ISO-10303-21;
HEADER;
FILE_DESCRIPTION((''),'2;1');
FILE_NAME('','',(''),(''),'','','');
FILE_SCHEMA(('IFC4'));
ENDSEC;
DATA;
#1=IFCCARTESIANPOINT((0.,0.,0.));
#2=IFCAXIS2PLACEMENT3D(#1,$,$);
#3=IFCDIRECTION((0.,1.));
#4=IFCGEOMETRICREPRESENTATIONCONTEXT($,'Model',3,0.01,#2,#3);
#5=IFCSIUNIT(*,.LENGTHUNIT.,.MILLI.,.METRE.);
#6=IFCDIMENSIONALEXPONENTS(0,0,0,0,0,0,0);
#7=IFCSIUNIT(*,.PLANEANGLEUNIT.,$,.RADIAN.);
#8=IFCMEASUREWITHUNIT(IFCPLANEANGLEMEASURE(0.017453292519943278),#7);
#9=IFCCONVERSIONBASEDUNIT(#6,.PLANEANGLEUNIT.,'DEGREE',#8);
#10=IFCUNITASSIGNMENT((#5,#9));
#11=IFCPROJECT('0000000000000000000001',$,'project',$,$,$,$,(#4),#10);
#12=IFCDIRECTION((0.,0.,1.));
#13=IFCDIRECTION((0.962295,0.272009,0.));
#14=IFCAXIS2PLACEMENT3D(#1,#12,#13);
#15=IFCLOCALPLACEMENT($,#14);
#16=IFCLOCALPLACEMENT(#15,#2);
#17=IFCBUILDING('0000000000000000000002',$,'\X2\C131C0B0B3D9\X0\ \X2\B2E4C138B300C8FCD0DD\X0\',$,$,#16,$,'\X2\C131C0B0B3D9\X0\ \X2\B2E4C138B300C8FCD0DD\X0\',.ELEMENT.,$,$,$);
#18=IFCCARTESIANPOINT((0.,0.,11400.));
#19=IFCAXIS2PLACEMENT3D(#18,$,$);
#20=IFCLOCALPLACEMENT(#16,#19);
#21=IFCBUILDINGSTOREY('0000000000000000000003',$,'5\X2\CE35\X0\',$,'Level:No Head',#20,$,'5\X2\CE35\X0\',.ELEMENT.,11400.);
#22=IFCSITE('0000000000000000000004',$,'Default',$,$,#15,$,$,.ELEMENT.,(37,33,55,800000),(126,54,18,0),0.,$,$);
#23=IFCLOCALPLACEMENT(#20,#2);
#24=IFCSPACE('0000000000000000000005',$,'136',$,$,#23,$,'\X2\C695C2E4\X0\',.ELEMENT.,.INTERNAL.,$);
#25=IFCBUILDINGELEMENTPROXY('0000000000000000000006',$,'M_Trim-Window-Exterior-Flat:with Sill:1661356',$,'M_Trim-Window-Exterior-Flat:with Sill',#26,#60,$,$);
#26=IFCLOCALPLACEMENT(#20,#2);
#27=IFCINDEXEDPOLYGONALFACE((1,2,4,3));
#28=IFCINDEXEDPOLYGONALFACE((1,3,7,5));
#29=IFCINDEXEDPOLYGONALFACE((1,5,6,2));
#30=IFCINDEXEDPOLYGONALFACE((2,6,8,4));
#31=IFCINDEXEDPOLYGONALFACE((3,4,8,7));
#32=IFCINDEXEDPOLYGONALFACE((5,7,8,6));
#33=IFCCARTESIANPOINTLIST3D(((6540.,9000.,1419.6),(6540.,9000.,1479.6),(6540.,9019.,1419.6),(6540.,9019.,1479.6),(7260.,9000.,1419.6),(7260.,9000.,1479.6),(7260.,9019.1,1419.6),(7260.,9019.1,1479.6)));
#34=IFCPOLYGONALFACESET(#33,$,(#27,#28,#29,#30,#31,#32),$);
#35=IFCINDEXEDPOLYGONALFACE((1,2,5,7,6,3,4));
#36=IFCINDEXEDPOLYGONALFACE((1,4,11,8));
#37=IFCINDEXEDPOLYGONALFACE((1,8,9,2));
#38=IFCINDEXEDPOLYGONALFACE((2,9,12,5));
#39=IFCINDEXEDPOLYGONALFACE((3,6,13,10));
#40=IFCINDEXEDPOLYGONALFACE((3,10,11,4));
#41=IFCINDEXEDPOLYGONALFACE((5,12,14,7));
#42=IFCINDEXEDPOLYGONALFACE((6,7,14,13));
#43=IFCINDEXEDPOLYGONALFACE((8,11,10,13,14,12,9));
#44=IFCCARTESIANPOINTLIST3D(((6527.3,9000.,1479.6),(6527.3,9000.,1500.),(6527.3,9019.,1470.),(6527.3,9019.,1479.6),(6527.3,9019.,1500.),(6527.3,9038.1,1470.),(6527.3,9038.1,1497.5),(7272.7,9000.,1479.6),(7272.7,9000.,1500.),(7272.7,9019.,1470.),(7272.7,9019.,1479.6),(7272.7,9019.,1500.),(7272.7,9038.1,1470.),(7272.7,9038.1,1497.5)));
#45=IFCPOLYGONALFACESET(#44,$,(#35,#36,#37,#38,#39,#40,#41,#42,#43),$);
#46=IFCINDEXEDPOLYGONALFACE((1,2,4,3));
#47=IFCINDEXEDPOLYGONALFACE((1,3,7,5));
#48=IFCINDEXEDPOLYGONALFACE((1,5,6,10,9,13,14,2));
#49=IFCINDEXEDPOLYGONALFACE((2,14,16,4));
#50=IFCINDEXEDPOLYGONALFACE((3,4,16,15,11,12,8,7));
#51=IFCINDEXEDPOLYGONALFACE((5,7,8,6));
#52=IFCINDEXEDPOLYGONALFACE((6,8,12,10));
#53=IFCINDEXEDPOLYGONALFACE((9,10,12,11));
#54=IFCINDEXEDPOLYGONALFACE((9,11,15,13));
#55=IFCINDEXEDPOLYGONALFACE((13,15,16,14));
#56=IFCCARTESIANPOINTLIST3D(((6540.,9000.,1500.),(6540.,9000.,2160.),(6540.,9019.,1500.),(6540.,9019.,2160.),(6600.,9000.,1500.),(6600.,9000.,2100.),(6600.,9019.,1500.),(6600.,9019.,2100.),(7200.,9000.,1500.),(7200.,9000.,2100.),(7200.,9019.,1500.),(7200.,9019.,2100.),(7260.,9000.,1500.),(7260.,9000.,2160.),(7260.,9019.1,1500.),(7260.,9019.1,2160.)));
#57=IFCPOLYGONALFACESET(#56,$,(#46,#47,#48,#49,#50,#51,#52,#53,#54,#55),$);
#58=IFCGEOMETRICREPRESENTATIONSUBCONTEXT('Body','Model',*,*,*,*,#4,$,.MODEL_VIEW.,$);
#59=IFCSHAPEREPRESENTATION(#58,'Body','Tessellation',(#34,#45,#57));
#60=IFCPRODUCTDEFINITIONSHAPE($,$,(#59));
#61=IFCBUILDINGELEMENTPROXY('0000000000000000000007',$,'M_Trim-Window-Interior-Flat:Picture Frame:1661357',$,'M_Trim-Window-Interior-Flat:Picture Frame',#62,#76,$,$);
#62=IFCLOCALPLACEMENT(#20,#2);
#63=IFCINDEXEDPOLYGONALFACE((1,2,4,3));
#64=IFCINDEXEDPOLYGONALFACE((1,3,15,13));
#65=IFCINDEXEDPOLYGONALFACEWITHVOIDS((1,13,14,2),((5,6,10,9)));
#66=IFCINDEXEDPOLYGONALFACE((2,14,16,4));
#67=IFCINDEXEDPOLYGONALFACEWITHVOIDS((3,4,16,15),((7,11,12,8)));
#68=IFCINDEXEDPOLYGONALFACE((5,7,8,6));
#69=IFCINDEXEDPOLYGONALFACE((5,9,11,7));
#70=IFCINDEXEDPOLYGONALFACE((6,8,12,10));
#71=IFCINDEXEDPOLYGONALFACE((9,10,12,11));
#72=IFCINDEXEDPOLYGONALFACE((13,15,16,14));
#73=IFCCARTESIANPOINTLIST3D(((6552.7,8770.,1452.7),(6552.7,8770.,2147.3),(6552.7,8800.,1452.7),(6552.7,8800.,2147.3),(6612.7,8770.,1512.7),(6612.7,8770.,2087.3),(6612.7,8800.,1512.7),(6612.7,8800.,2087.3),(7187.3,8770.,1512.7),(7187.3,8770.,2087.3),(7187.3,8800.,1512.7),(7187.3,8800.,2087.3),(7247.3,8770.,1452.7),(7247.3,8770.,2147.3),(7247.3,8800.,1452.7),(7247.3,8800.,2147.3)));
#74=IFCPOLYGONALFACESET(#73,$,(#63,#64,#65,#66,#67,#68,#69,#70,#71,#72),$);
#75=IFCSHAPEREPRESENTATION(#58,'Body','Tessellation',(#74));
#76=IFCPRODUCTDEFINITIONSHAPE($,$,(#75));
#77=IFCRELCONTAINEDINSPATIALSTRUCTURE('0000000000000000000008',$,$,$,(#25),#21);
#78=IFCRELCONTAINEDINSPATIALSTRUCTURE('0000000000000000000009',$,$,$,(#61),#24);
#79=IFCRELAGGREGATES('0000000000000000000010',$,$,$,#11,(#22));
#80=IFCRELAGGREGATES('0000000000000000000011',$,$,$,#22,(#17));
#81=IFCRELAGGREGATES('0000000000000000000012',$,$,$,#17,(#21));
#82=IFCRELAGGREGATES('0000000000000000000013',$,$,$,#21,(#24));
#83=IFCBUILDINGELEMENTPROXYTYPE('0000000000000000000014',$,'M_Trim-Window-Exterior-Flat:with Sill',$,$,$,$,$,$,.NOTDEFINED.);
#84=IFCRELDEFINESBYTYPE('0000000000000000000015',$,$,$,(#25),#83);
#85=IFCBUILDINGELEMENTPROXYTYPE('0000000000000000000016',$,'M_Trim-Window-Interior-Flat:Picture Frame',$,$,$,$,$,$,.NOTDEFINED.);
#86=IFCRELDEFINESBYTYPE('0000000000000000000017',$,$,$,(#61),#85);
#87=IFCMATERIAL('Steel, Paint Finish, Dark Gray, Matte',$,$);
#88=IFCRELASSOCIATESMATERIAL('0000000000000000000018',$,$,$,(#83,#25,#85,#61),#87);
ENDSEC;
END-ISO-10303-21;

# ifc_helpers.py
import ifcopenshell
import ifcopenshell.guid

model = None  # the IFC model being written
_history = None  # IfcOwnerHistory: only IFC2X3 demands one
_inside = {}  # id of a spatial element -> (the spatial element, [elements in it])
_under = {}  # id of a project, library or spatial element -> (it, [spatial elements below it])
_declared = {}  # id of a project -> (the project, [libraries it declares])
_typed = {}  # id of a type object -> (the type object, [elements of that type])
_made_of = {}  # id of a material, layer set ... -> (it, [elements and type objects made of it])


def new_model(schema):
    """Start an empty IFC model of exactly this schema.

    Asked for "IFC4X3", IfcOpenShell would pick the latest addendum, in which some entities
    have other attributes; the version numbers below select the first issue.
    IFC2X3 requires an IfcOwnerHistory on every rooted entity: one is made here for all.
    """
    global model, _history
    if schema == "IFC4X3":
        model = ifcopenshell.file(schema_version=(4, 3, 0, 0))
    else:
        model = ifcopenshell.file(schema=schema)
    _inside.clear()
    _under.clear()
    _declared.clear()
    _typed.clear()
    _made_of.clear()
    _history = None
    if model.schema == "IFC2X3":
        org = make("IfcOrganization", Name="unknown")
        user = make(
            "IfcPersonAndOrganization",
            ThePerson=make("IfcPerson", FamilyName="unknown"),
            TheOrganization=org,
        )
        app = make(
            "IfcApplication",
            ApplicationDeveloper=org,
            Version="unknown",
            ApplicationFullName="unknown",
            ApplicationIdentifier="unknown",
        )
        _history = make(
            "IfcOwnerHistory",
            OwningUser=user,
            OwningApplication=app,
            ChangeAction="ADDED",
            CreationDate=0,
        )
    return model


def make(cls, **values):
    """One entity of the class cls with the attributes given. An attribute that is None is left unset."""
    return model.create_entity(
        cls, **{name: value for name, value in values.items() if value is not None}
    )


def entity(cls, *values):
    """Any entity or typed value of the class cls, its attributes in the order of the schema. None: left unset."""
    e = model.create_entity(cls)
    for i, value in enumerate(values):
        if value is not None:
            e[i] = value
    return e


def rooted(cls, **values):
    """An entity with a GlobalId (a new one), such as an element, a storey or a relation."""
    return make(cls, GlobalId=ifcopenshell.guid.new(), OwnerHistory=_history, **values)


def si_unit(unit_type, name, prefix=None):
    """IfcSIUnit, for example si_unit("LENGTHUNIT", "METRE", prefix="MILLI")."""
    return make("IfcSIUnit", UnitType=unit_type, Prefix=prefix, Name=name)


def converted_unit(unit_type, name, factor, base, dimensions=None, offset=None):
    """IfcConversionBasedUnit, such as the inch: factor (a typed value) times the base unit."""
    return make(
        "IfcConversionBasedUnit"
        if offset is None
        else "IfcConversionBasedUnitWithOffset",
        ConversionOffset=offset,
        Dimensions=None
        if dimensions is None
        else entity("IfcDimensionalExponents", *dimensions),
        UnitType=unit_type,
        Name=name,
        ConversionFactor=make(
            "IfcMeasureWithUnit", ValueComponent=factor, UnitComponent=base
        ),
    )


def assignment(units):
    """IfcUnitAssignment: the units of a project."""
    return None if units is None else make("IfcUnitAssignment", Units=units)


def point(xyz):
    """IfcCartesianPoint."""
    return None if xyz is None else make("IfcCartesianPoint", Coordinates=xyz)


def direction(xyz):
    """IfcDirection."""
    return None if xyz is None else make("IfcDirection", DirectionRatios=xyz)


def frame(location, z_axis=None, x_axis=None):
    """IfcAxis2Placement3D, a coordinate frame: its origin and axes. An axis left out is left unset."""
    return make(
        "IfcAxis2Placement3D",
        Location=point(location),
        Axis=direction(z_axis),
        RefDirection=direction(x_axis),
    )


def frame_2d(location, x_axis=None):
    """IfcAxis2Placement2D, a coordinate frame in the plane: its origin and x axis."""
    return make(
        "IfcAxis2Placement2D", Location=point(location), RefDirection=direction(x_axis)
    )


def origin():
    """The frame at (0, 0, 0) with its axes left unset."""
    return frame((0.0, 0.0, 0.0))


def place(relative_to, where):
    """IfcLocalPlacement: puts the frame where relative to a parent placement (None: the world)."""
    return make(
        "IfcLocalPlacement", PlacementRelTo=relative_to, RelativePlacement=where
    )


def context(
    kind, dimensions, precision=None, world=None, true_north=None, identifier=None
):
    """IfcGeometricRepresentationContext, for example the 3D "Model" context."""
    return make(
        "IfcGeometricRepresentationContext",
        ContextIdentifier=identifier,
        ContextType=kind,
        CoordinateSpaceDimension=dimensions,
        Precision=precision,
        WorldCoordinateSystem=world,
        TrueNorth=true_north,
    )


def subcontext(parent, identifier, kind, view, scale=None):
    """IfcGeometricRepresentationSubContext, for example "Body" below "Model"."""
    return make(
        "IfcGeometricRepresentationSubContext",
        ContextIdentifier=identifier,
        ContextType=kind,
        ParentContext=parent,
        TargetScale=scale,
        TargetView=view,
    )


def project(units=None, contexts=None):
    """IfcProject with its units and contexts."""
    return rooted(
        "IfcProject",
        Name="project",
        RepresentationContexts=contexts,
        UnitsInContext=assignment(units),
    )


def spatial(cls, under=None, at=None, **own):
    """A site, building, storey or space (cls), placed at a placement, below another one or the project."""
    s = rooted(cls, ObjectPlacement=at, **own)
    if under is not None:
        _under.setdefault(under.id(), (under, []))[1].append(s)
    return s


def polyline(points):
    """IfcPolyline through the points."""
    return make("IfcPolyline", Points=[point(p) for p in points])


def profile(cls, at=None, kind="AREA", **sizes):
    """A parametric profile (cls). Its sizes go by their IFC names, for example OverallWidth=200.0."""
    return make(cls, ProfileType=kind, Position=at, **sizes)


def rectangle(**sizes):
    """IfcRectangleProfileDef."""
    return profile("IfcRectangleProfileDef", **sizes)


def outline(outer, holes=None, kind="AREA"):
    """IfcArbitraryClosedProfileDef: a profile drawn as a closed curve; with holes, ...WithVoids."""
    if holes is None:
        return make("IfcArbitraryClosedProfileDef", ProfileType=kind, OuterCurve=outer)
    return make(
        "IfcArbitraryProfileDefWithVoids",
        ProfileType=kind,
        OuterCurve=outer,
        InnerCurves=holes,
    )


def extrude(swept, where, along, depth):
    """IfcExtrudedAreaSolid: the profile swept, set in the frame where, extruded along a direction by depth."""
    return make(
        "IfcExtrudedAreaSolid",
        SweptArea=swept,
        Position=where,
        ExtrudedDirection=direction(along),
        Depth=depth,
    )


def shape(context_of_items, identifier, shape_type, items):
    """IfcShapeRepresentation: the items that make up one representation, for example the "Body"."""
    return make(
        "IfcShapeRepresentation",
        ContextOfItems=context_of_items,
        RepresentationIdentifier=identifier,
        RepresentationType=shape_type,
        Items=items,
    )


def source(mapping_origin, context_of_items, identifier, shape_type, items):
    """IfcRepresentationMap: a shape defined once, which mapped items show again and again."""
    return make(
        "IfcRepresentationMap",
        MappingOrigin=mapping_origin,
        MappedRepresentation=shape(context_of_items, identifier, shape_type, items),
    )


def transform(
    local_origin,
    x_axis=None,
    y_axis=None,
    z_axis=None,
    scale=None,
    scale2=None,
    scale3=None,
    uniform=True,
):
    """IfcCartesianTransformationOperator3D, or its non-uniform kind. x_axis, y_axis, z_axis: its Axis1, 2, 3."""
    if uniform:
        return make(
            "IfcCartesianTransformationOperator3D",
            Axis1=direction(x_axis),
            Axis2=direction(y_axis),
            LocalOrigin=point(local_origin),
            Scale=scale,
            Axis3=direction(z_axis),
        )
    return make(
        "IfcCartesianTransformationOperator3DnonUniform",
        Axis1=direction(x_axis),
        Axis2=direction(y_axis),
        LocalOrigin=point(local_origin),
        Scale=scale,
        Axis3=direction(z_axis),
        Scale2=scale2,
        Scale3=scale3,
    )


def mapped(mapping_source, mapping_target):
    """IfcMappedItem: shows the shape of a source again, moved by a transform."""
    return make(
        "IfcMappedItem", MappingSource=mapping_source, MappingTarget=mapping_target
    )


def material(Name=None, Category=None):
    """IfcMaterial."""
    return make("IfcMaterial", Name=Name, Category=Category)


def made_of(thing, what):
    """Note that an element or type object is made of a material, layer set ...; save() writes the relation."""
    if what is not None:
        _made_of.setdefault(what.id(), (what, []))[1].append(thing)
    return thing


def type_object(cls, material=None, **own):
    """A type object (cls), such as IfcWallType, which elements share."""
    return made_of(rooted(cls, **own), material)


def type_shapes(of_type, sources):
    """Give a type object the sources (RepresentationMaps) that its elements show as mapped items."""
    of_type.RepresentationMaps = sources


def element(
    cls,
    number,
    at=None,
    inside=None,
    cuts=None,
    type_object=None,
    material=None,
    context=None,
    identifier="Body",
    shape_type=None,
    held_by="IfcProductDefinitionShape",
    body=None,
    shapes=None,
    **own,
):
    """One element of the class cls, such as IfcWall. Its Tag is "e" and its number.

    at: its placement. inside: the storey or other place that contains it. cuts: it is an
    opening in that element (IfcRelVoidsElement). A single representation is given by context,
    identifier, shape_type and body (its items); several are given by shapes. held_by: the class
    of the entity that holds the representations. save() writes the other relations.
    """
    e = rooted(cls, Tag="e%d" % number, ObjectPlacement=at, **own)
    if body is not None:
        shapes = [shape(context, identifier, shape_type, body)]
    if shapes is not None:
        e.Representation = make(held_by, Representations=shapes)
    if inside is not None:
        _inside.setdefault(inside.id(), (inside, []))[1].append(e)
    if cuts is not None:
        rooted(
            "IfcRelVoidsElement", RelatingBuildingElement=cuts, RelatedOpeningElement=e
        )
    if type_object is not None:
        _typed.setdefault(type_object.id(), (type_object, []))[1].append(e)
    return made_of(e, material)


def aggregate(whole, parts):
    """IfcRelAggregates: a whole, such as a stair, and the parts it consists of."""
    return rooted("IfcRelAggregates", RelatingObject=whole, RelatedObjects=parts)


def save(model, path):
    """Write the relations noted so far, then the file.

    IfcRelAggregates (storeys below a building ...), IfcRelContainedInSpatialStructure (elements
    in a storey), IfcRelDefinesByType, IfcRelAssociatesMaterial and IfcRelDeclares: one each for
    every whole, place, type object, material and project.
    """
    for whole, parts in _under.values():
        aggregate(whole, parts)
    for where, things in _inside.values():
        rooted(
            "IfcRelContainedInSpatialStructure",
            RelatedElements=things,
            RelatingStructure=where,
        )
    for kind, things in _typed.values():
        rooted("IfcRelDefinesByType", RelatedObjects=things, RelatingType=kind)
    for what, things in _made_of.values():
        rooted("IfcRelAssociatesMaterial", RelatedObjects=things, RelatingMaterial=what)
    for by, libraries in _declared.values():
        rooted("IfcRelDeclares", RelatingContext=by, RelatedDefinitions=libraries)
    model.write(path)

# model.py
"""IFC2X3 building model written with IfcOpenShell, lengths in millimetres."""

from ifc_helpers import new_model, entity, si_unit, converted_unit, direction, frame, frame_2d, origin, place, context, subcontext, project, spatial, polyline, rectangle, outline, extrude, source, transform, mapped, material, type_object, type_shapes, element, save


model = new_model("IFC2X3")

# Units and contexts
model_context = context("Model", 3, precision=0.01, world=origin(), true_north=direction((0.0, 1.0)))
body_context = subcontext(model_context, "Body", "Model", "MODEL_VIEW")
ifc_project = project(units=[si_unit("LENGTHUNIT", "METRE", prefix="MILLI"), converted_unit("PLANEANGLEUNIT", "DEGREE", entity("IfcPlaneAngleMeasure", 0.017453292519943278), si_unit("PLANEANGLEUNIT", "RADIAN"), dimensions=[0, 0, 0, 0, 0, 0, 0])], contexts=[model_context])

# Site, building, storey
site_placement = place(None, frame((0.0, 0.0, 0.0), z_axis=(0.0, 0.0, 1.0), x_axis=(0.962295, 0.272009, 0.0)))
site = spatial("IfcSite", under=ifc_project, at=site_placement, Name="Default", CompositionType="ELEMENT", RefLatitude=(37, 33, 55, 800000), RefLongitude=(126, 54, 18, 0), RefElevation=0.0)
building_placement = place(site_placement, origin())
building = spatial("IfcBuilding", under=site, at=building_placement, Name="성산동 다세대주택", LongName="성산동 다세대주택", CompositionType="ELEMENT")
storey_placement = place(building_placement, frame((0.0, 0.0, 11400.0)))
storey = spatial("IfcBuildingStorey", under=building, at=storey_placement, Name="5층", ObjectType="Level:No Head", LongName="5층", CompositionType="ELEMENT", Elevation=11400.0)

# Building element proxy
ifc_material_1 = material(Name="Steel, Paint Finish, Dark Gray, Matte")
building_element_proxy_type_1 = type_object("IfcBuildingElementProxyType", Name="M_Trim-Window-Exterior-Flat:with Sill", PredefinedType="NOTDEFINED", material=ifc_material_1)
shared_shape_1 = source(origin(), body_context, "Body", "SweptSolid", [
    extrude(rectangle(XDim=720.0, YDim=60.0, at=frame_2d((0.0, 0.0), x_axis=(1.0, 0.0))), frame((0.0, -650.4, 0.0), z_axis=(0.0, 0.0, 1.0), x_axis=(-1.0, 0.0, 0.0)), (0.0, 0.0, 1.0), 19.0),
    extrude(outline(polyline([(-19.0, -15.2), (0.0, -15.2), (0.0, -5.7), (19.0, -5.7), (19.0, 14.8), (0.0, 14.8), (-19.0, 12.3), (-19.0, -15.2)])), frame((-372.7, -614.8, 19.0), z_axis=(1.0, 0.0, 0.0), x_axis=(0.0, 0.0, -1.0)), (0.0, 0.0, 1.0), 745.4),
    extrude(outline(polyline([(-345.0, -360.0), (315.0, -360.0), (315.0, -300.0), (-285.0, -300.0), (-285.0, 300.0), (315.0, 300.0), (315.0, 360.0), (-345.0, 360.0), (-345.0, -360.0)])), frame((0.0, -285.0, 0.0), z_axis=(0.0, 0.0, 1.0), x_axis=(0.0, -1.0, 0.0)), (0.0, 0.0, 1.0), 19.0),
])
type_shapes(building_element_proxy_type_1, [shared_shape_1])
proxy_1_placement = place(storey_placement, frame((6900.0, 9000.0, 2100.0), z_axis=(0.0, 1.0, 0.0), x_axis=(-1.0, 0.0, 0.0)))
element("IfcBuildingElementProxy", 1, at=proxy_1_placement, inside=storey, type_object=building_element_proxy_type_1, material=ifc_material_1, Name="M_Trim-Window-Exterior-Flat:with Sill:1661356", ObjectType="M_Trim-Window-Exterior-Flat:with Sill", context=body_context, shape_type="MappedRepresentation", body=[
    mapped(shared_shape_1, transform((0.0, 0.0, 0.0), scale=1.0)),
])

# Shared definitions
space_1_placement = place(storey_placement, origin())
space_1 = spatial("IfcSpace", under=storey, at=space_1_placement, Name="136", LongName="욕실", CompositionType="ELEMENT", InteriorOrExteriorSpace="INTERNAL")

# Building element proxy
building_element_proxy_type_2 = type_object("IfcBuildingElementProxyType", Name="M_Trim-Window-Interior-Flat:Picture Frame", PredefinedType="NOTDEFINED", material=ifc_material_1)
shared_shape_2 = source(origin(), body_context, "Body", "SweptSolid", [
    extrude(outline(polyline([(-347.3, -347.3), (347.3, -347.3), (347.3, 347.3), (-347.3, 347.3), (-347.3, -347.3)]), holes=[polyline([(-287.3, -287.3), (-287.3, 287.3), (287.3, 287.3), (287.3, -287.3), (-287.3, -287.3)])]), frame((0.0, -300.0, 0.0), z_axis=(0.0, 0.0, 1.0), x_axis=(-1.0, 0.0, 0.0)), (0.0, 0.0, 1.0), 30.0),
])
type_shapes(building_element_proxy_type_2, [shared_shape_2])
proxy_2_placement = place(space_1_placement, frame((6900.0, 8800.0, 2100.0), z_axis=(0.0, -1.0, 0.0), x_axis=(1.0, 0.0, 0.0)))
element("IfcBuildingElementProxy", 2, at=proxy_2_placement, inside=space_1, type_object=building_element_proxy_type_2, material=ifc_material_1, Name="M_Trim-Window-Interior-Flat:Picture Frame:1661357", ObjectType="M_Trim-Window-Interior-Flat:Picture Frame", context=body_context, shape_type="MappedRepresentation", body=[
    mapped(shared_shape_2, transform((0.0, 0.0, 0.0), scale=1.0)),
])

save(model, "model.ifc")
